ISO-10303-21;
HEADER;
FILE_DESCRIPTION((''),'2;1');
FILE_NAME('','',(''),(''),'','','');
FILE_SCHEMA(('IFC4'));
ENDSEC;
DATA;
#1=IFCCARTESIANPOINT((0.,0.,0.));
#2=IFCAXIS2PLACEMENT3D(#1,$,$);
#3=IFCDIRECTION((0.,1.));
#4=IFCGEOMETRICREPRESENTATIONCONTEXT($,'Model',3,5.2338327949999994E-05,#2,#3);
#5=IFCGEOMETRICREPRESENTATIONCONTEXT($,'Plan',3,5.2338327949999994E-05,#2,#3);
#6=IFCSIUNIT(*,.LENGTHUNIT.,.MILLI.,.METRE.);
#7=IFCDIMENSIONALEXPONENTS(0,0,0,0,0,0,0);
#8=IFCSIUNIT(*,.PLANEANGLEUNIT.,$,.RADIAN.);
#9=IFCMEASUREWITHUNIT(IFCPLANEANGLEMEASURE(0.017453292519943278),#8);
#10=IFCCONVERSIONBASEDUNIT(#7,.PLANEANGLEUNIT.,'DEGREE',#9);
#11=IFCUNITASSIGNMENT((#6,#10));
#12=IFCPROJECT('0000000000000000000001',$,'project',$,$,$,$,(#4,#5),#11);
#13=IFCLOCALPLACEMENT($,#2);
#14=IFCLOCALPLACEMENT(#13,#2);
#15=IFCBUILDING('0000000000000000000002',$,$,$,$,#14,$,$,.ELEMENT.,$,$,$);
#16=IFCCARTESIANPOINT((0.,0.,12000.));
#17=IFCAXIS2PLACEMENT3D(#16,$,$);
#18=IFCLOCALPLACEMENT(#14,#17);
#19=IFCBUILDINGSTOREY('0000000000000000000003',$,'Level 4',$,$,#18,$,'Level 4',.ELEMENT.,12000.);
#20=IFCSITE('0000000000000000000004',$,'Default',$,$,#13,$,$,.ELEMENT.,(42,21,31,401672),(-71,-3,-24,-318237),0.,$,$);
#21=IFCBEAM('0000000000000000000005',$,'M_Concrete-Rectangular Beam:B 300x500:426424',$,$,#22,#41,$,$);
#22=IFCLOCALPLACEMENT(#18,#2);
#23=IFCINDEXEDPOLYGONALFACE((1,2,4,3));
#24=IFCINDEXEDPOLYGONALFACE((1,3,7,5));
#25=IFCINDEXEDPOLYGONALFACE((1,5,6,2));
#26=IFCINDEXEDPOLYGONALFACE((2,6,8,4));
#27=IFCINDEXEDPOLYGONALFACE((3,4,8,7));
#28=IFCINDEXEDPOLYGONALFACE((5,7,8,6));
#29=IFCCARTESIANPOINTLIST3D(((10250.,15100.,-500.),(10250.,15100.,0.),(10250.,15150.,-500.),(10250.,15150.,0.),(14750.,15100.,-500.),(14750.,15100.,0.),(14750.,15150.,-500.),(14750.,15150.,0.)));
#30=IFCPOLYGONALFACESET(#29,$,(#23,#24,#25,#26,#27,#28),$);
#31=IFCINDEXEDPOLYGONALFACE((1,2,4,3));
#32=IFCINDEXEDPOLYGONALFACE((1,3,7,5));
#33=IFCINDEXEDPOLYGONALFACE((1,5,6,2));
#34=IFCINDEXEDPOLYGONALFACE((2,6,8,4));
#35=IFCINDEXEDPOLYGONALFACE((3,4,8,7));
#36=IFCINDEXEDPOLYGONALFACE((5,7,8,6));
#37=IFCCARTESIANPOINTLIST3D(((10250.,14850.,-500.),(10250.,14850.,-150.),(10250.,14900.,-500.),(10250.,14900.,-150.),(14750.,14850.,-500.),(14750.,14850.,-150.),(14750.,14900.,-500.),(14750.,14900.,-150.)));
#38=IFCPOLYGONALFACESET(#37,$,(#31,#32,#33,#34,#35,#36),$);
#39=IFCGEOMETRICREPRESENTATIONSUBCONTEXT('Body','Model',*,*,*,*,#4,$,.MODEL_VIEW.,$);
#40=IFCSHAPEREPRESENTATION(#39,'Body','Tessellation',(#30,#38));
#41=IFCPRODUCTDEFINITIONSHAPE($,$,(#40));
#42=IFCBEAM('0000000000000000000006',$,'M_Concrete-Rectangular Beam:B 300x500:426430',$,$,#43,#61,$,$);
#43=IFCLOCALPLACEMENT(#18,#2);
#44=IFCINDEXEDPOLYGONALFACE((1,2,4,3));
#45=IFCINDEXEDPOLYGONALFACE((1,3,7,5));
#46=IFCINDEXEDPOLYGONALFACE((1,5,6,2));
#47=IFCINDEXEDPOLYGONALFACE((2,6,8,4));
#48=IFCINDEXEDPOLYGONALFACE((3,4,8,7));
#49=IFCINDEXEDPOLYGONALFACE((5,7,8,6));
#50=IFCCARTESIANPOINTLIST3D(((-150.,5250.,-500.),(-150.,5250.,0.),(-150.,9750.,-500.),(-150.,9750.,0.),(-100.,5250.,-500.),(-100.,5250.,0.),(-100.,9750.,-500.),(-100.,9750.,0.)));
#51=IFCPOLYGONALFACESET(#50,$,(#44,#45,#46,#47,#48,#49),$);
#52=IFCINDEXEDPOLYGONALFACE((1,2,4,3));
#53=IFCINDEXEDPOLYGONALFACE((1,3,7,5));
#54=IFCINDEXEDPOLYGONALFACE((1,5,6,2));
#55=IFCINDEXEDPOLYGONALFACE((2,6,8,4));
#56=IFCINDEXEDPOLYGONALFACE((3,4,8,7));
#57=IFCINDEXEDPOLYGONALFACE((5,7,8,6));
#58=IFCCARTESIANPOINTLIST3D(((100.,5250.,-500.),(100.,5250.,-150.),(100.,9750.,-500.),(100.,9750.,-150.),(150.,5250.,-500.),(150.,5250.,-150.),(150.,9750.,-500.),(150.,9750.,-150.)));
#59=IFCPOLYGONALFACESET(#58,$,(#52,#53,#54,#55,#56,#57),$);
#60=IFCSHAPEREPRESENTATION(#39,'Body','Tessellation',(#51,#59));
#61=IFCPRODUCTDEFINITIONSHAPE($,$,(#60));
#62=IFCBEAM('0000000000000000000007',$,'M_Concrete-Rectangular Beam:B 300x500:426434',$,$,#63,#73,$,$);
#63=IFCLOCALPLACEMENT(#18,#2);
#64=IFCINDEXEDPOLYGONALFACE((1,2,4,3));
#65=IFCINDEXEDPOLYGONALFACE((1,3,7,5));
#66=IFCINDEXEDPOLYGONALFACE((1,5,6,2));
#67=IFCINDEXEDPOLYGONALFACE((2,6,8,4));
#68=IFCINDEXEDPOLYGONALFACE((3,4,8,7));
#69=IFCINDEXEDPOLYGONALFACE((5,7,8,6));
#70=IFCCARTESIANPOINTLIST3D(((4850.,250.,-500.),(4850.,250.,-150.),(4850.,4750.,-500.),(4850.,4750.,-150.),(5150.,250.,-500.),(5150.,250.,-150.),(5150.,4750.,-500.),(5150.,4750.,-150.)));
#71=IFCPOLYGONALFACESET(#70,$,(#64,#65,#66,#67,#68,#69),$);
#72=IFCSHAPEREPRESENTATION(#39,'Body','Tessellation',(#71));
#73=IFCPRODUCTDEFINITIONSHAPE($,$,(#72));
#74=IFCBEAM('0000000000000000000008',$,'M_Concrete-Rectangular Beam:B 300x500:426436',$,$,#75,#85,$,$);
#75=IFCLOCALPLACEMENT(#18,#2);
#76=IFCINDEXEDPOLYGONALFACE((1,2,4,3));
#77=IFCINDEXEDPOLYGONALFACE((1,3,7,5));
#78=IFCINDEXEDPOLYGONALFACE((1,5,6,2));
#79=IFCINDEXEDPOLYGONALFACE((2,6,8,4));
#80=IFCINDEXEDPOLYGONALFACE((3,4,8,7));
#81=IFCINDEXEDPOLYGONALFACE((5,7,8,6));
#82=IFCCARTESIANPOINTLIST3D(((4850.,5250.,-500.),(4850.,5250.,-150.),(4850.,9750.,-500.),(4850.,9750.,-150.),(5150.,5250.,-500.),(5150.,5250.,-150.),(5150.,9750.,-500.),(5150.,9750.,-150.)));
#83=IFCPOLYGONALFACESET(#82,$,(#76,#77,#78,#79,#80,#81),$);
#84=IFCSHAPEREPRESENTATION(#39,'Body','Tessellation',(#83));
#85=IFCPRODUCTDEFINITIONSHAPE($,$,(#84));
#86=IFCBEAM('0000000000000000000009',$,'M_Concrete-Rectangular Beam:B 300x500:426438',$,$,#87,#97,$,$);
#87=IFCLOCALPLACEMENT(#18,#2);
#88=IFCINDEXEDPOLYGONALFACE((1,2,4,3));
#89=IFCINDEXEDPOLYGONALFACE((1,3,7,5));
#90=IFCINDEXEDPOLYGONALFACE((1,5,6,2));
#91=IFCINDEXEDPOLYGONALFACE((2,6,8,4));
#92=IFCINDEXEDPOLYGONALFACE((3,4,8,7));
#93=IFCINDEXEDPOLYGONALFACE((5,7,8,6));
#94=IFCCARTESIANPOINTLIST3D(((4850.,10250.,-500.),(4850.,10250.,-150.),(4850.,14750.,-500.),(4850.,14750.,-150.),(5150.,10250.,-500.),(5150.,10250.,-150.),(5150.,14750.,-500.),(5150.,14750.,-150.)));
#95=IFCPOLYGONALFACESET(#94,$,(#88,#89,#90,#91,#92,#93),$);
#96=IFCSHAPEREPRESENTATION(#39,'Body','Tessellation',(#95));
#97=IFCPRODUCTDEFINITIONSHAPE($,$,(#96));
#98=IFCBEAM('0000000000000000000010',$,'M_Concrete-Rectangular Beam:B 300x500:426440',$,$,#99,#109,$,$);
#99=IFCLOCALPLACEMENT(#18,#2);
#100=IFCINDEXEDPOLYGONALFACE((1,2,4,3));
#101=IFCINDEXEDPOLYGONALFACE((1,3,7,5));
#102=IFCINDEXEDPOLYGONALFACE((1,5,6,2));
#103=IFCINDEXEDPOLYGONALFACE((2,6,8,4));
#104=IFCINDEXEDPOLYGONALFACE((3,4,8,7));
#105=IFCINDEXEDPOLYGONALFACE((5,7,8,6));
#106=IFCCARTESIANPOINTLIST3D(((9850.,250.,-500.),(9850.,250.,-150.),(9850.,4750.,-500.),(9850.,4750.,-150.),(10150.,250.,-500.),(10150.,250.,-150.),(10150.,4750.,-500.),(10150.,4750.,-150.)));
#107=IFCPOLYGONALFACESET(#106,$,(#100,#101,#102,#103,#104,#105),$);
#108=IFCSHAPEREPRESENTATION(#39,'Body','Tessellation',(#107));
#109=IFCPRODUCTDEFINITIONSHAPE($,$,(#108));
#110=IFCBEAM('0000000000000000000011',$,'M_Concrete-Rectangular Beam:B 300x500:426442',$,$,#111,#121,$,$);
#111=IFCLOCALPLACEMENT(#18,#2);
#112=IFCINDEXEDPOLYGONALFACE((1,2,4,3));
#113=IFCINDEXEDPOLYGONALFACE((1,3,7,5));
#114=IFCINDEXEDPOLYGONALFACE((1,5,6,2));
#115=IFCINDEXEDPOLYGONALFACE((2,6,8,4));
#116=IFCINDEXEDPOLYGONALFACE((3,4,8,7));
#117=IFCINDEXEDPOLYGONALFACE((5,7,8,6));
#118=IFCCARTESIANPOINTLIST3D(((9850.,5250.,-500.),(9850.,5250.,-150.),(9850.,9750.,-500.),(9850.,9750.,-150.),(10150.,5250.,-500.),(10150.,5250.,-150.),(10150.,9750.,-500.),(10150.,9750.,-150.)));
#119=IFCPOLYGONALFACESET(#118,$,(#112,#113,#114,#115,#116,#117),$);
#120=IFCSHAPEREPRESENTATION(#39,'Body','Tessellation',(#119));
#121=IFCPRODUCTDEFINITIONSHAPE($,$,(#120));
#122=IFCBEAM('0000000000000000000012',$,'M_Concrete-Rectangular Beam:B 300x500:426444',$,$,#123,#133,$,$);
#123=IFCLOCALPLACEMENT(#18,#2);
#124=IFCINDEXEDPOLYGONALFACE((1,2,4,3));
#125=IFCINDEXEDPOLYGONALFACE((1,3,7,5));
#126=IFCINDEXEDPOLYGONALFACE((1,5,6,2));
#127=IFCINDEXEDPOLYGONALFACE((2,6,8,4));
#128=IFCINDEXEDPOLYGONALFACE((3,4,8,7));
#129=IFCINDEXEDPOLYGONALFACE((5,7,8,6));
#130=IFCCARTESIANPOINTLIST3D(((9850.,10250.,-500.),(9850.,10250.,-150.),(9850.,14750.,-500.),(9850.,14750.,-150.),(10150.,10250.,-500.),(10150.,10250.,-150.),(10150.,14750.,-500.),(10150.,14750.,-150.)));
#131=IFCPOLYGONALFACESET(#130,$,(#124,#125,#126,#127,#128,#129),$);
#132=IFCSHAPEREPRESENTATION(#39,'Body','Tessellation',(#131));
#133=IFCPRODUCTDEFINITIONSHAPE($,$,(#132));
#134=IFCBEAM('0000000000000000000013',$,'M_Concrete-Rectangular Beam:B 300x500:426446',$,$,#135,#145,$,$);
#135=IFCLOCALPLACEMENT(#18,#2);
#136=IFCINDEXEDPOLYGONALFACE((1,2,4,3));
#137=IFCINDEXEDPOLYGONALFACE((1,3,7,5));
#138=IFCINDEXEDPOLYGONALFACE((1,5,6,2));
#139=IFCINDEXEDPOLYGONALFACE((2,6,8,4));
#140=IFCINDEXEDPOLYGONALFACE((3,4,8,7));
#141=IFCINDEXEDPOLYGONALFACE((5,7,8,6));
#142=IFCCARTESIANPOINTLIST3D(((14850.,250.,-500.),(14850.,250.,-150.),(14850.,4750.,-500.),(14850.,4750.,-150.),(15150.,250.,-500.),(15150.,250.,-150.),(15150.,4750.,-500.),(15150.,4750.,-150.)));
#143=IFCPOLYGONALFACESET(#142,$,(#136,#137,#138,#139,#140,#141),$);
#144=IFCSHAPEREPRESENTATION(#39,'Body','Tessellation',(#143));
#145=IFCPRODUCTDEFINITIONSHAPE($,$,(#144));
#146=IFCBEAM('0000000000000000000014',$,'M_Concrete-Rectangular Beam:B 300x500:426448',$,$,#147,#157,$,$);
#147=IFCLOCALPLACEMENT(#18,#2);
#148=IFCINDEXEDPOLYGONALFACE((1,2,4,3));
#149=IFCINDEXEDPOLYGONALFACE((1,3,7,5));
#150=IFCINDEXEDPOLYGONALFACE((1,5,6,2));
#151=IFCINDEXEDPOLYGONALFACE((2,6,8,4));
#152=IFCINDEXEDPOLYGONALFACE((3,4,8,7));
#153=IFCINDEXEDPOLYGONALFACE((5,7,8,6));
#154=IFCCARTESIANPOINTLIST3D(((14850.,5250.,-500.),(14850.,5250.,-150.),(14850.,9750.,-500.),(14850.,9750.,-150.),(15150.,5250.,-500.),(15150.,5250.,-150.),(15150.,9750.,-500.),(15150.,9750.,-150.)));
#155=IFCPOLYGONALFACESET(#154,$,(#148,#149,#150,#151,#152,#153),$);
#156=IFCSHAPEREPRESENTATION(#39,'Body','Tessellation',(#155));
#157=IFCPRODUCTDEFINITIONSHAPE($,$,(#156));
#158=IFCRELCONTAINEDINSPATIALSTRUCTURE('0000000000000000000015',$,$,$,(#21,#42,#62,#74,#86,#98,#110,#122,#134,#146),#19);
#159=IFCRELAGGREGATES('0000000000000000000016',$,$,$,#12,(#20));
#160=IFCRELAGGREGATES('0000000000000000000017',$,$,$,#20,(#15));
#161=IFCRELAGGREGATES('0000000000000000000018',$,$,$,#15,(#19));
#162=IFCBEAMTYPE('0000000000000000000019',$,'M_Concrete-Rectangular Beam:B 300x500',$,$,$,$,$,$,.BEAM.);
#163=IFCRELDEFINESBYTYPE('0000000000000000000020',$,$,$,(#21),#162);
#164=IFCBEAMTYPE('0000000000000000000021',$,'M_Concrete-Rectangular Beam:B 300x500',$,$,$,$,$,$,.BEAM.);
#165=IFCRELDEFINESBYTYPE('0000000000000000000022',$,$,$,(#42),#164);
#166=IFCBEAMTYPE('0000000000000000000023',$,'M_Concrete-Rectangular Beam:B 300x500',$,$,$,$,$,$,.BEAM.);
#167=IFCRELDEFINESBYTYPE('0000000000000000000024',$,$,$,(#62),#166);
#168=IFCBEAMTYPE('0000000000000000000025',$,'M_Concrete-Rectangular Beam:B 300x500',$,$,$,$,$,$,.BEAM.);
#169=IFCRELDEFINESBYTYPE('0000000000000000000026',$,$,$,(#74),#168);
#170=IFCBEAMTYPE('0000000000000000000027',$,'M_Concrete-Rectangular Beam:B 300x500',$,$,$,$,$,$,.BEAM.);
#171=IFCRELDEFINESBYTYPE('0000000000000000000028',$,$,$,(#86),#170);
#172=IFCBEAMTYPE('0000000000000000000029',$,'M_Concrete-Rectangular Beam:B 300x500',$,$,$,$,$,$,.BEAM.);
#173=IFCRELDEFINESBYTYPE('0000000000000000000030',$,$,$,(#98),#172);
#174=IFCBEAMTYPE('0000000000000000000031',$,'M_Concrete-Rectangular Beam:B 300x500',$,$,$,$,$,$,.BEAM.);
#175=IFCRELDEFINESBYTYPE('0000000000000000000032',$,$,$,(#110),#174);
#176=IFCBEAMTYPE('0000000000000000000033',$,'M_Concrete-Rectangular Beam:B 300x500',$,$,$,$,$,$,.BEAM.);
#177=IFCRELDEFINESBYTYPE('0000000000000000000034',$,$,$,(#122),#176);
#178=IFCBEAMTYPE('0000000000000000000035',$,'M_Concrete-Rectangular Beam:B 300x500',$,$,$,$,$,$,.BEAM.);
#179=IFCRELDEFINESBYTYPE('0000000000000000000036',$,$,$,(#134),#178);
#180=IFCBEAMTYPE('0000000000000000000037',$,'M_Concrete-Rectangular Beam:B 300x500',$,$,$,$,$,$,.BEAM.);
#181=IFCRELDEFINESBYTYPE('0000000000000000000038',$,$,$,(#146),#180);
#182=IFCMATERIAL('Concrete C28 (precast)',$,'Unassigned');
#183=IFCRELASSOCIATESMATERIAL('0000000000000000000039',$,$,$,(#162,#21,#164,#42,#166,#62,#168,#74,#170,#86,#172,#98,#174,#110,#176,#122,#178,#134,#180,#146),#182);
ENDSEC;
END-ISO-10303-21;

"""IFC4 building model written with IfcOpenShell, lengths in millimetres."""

from ifc_helpers import new_model, entity, si_unit, converted_unit, direction, frame, origin, place, context, subcontext, project, spatial, indexed_curve, outline, extrude, source, transform, mapped, material, type_object, type_shapes, element, save


model = new_model("IFC4")

# Units and contexts
model_context = context("Model", 3, precision=5.2338327949999994e-05, world=origin(), true_north=direction((0.0, 1.0)))
plan_context = context("Plan", 3, precision=5.2338327949999994e-05, world=origin(), true_north=direction((0.0, 1.0)))
body_context = subcontext(model_context, "Body", "Model", "MODEL_VIEW")
ifc_project = project(units=[si_unit("LENGTHUNIT", "METRE", prefix="MILLI"), converted_unit("PLANEANGLEUNIT", "DEGREE", entity("IfcPlaneAngleMeasure", 0.017453292519943278), si_unit("PLANEANGLEUNIT", "RADIAN"), dimensions=[0, 0, 0, 0, 0, 0, 0])], contexts=[model_context, plan_context])

# Site, building, storey
site_placement = place(None, origin())
site = spatial("IfcSite", under=ifc_project, at=site_placement, Name="Default", CompositionType="ELEMENT", RefLatitude=(42, 21, 31, 401672), RefLongitude=(-71, -3, -24, -318237), RefElevation=0.0)
building_placement = place(site_placement, origin())
building = spatial("IfcBuilding", under=site, at=building_placement, CompositionType="ELEMENT")
storey_placement = place(building_placement, frame((0.0, 0.0, 12000.0)))
storey = spatial("IfcBuildingStorey", under=building, at=storey_placement, Name="Level 4", LongName="Level 4", CompositionType="ELEMENT", Elevation=12000.0)

# Beams
ifc_material = material(Name="Concrete C28 (precast)", Category="Unassigned")
beam_type_1 = type_object("IfcBeamType", Name="M_Concrete-Rectangular Beam:B 300x500", PredefinedType="BEAM", material=ifc_material)
shared_shape_1 = source(origin(), body_context, "Body", "SweptSolid", [
    extrude(outline(indexed_curve([(-250.0, -25.0), (250.0, -25.0), (250.0, 25.0), (-250.0, 25.0), (-250.0, -25.0)], self_intersect=False)), frame((10250.0, 15125.0, 11750.0), z_axis=(1.0, 0.0, 0.0), x_axis=(0.0, 0.0, -1.0)), (0.0, 0.0, 1.0), 4500.0),
    extrude(outline(indexed_curve([(-175.0, -25.0), (175.0, -25.0), (175.0, 25.0), (-175.0, 25.0), (-175.0, -25.0)], self_intersect=False)), frame((10250.0, 14875.0, 11675.0), z_axis=(1.0, 0.0, 0.0), x_axis=(0.0, 0.0, -1.0)), (0.0, 0.0, 1.0), 4500.0),
])
type_shapes(beam_type_1, [shared_shape_1])
beam_1_placement = place(storey_placement, frame((0.0, 0.0, -12000.0)))
element("IfcBeam", 1, at=beam_1_placement, inside=storey, type_object=beam_type_1, material=ifc_material, Name="M_Concrete-Rectangular Beam:B 300x500:426424", context=body_context, shape_type="MappedRepresentation", body=[
    mapped(shared_shape_1, transform((0.0, 0.0, 0.0), scale=1.0)),
])
beam_type_2 = type_object("IfcBeamType", Name="M_Concrete-Rectangular Beam:B 300x500", PredefinedType="BEAM", material=ifc_material)
shared_shape_2 = source(origin(), body_context, "Body", "SweptSolid", [
    extrude(outline(indexed_curve([(-25.0, -250.0), (25.0, -250.0), (25.0, 250.0), (-25.0, 250.0), (-25.0, -250.0)], self_intersect=False)), frame((-125.0, 5250.0, 11750.0), z_axis=(0.0, 1.0, 0.0), x_axis=(-1.0, 0.0, 0.0)), (0.0, 0.0, 1.0), 4500.0),
    extrude(outline(indexed_curve([(-25.0, -175.0), (25.0, -175.0), (25.0, 175.0), (-25.0, 175.0), (-25.0, -175.0)], self_intersect=False)), frame((125.0, 5250.0, 11675.0), z_axis=(0.0, 1.0, 0.0), x_axis=(-1.0, 0.0, 0.0)), (0.0, 0.0, 1.0), 4500.0),
])
type_shapes(beam_type_2, [shared_shape_2])
beam_2_placement = place(storey_placement, frame((0.0, 0.0, -12000.0)))
element("IfcBeam", 2, at=beam_2_placement, inside=storey, type_object=beam_type_2, material=ifc_material, Name="M_Concrete-Rectangular Beam:B 300x500:426430", context=body_context, shape_type="MappedRepresentation", body=[
    mapped(shared_shape_2, transform((0.0, 0.0, 0.0), scale=1.0)),
])
beam_type_3 = type_object("IfcBeamType", Name="M_Concrete-Rectangular Beam:B 300x500", PredefinedType="BEAM", material=ifc_material)
shared_shape_3 = source(origin(), body_context, "Body", "SweptSolid", [
    extrude(outline(indexed_curve([(-150.0, -175.0), (150.0, -175.0), (150.0, 175.0), (-150.0, 175.0), (-150.0, -175.0)], self_intersect=False)), frame((5000.0, 250.0, 11675.0), z_axis=(0.0, 1.0, 0.0), x_axis=(-1.0, 0.0, 0.0)), (0.0, 0.0, 1.0), 4500.0),
])
type_shapes(beam_type_3, [shared_shape_3])
beam_3_placement = place(storey_placement, frame((0.0, 0.0, -12000.0)))
element("IfcBeam", 3, at=beam_3_placement, inside=storey, type_object=beam_type_3, material=ifc_material, Name="M_Concrete-Rectangular Beam:B 300x500:426434", context=body_context, shape_type="MappedRepresentation", body=[
    mapped(shared_shape_3, transform((0.0, 0.0, 0.0), scale=1.0)),
])
beam_type_4 = type_object("IfcBeamType", Name="M_Concrete-Rectangular Beam:B 300x500", PredefinedType="BEAM", material=ifc_material)
shared_shape_4 = source(origin(), body_context, "Body", "SweptSolid", [
    extrude(outline(indexed_curve([(-150.0, -175.0), (150.0, -175.0), (150.0, 175.0), (-150.0, 175.0), (-150.0, -175.0)], self_intersect=False)), frame((5000.0, 5250.0, 11675.0), z_axis=(0.0, 1.0, 0.0), x_axis=(-1.0, 0.0, 0.0)), (0.0, 0.0, 1.0), 4500.0),
])
type_shapes(beam_type_4, [shared_shape_4])
beam_4_placement = place(storey_placement, frame((0.0, 0.0, -12000.0)))
element("IfcBeam", 4, at=beam_4_placement, inside=storey, type_object=beam_type_4, material=ifc_material, Name="M_Concrete-Rectangular Beam:B 300x500:426436", context=body_context, shape_type="MappedRepresentation", body=[
    mapped(shared_shape_4, transform((0.0, 0.0, 0.0), scale=1.0)),
])
beam_type_5 = type_object("IfcBeamType", Name="M_Concrete-Rectangular Beam:B 300x500", PredefinedType="BEAM", material=ifc_material)
shared_shape_5 = source(origin(), body_context, "Body", "SweptSolid", [
    extrude(outline(indexed_curve([(-150.0, -175.0), (150.0, -175.0), (150.0, 175.0), (-150.0, 175.0), (-150.0, -175.0)], self_intersect=False)), frame((5000.0, 10250.0, 11675.0), z_axis=(0.0, 1.0, 0.0), x_axis=(-1.0, 0.0, 0.0)), (0.0, 0.0, 1.0), 4500.0),
])
type_shapes(beam_type_5, [shared_shape_5])
beam_5_placement = place(storey_placement, frame((0.0, 0.0, -12000.0)))
element("IfcBeam", 5, at=beam_5_placement, inside=storey, type_object=beam_type_5, material=ifc_material, Name="M_Concrete-Rectangular Beam:B 300x500:426438", context=body_context, shape_type="MappedRepresentation", body=[
    mapped(shared_shape_5, transform((0.0, 0.0, 0.0), scale=1.0)),
])
beam_type_6 = type_object("IfcBeamType", Name="M_Concrete-Rectangular Beam:B 300x500", PredefinedType="BEAM", material=ifc_material)
shared_shape_6 = source(origin(), body_context, "Body", "SweptSolid", [
    extrude(outline(indexed_curve([(-150.0, -175.0), (150.0, -175.0), (150.0, 175.0), (-150.0, 175.0), (-150.0, -175.0)], self_intersect=False)), frame((10000.0, 250.0, 11675.0), z_axis=(0.0, 1.0, 0.0), x_axis=(-1.0, 0.0, 0.0)), (0.0, 0.0, 1.0), 4500.0),
])
type_shapes(beam_type_6, [shared_shape_6])
beam_6_placement = place(storey_placement, frame((0.0, 0.0, -12000.0)))
element("IfcBeam", 6, at=beam_6_placement, inside=storey, type_object=beam_type_6, material=ifc_material, Name="M_Concrete-Rectangular Beam:B 300x500:426440", context=body_context, shape_type="MappedRepresentation", body=[
    mapped(shared_shape_6, transform((0.0, 0.0, 0.0), scale=1.0)),
])
beam_type_7 = type_object("IfcBeamType", Name="M_Concrete-Rectangular Beam:B 300x500", PredefinedType="BEAM", material=ifc_material)
shared_shape_7 = source(origin(), body_context, "Body", "SweptSolid", [
    extrude(outline(indexed_curve([(-150.0, -175.0), (150.0, -175.0), (150.0, 175.0), (-150.0, 175.0), (-150.0, -175.0)], self_intersect=False)), frame((10000.0, 5250.0, 11675.0), z_axis=(0.0, 1.0, 0.0), x_axis=(-1.0, 0.0, 0.0)), (0.0, 0.0, 1.0), 4500.0),
])
type_shapes(beam_type_7, [shared_shape_7])
beam_7_placement = place(storey_placement, frame((0.0, 0.0, -12000.0)))
element("IfcBeam", 7, at=beam_7_placement, inside=storey, type_object=beam_type_7, material=ifc_material, Name="M_Concrete-Rectangular Beam:B 300x500:426442", context=body_context, shape_type="MappedRepresentation", body=[
    mapped(shared_shape_7, transform((0.0, 0.0, 0.0), scale=1.0)),
])
beam_type_8 = type_object("IfcBeamType", Name="M_Concrete-Rectangular Beam:B 300x500", PredefinedType="BEAM", material=ifc_material)
shared_shape_8 = source(origin(), body_context, "Body", "SweptSolid", [
    extrude(outline(indexed_curve([(-150.0, -175.0), (150.0, -175.0), (150.0, 175.0), (-150.0, 175.0), (-150.0, -175.0)], self_intersect=False)), frame((10000.0, 10250.0, 11675.0), z_axis=(0.0, 1.0, 0.0), x_axis=(-1.0, 0.0, 0.0)), (0.0, 0.0, 1.0), 4500.0),
])
type_shapes(beam_type_8, [shared_shape_8])
beam_8_placement = place(storey_placement, frame((0.0, 0.0, -12000.0)))
element("IfcBeam", 8, at=beam_8_placement, inside=storey, type_object=beam_type_8, material=ifc_material, Name="M_Concrete-Rectangular Beam:B 300x500:426444", context=body_context, shape_type="MappedRepresentation", body=[
    mapped(shared_shape_8, transform((0.0, 0.0, 0.0), scale=1.0)),
])
beam_type_9 = type_object("IfcBeamType", Name="M_Concrete-Rectangular Beam:B 300x500", PredefinedType="BEAM", material=ifc_material)
shared_shape_9 = source(origin(), body_context, "Body", "SweptSolid", [
    extrude(outline(indexed_curve([(-150.0, -175.0), (150.0, -175.0), (150.0, 175.0), (-150.0, 175.0), (-150.0, -175.0)], self_intersect=False)), frame((15000.0, 250.0, 11675.0), z_axis=(0.0, 1.0, 0.0), x_axis=(-1.0, 0.0, 0.0)), (0.0, 0.0, 1.0), 4500.0),
])
type_shapes(beam_type_9, [shared_shape_9])
beam_9_placement = place(storey_placement, frame((0.0, 0.0, -12000.0)))
element("IfcBeam", 9, at=beam_9_placement, inside=storey, type_object=beam_type_9, material=ifc_material, Name="M_Concrete-Rectangular Beam:B 300x500:426446", context=body_context, shape_type="MappedRepresentation", body=[
    mapped(shared_shape_9, transform((0.0, 0.0, 0.0), scale=1.0)),
])
beam_type_10 = type_object("IfcBeamType", Name="M_Concrete-Rectangular Beam:B 300x500", PredefinedType="BEAM", material=ifc_material)
shared_shape_10 = source(origin(), body_context, "Body", "SweptSolid", [
    extrude(outline(indexed_curve([(-150.0, -175.0), (150.0, -175.0), (150.0, 175.0), (-150.0, 175.0), (-150.0, -175.0)], self_intersect=False)), frame((15000.0, 5250.0, 11675.0), z_axis=(0.0, 1.0, 0.0), x_axis=(-1.0, 0.0, 0.0)), (0.0, 0.0, 1.0), 4500.0),
])
type_shapes(beam_type_10, [shared_shape_10])
beam_10_placement = place(storey_placement, frame((0.0, 0.0, -12000.0)))
element("IfcBeam", 10, at=beam_10_placement, inside=storey, type_object=beam_type_10, material=ifc_material, Name="M_Concrete-Rectangular Beam:B 300x500:426448", context=body_context, shape_type="MappedRepresentation", body=[
    mapped(shared_shape_10, transform((0.0, 0.0, 0.0), scale=1.0)),
])

save(model, "model.ifc")
